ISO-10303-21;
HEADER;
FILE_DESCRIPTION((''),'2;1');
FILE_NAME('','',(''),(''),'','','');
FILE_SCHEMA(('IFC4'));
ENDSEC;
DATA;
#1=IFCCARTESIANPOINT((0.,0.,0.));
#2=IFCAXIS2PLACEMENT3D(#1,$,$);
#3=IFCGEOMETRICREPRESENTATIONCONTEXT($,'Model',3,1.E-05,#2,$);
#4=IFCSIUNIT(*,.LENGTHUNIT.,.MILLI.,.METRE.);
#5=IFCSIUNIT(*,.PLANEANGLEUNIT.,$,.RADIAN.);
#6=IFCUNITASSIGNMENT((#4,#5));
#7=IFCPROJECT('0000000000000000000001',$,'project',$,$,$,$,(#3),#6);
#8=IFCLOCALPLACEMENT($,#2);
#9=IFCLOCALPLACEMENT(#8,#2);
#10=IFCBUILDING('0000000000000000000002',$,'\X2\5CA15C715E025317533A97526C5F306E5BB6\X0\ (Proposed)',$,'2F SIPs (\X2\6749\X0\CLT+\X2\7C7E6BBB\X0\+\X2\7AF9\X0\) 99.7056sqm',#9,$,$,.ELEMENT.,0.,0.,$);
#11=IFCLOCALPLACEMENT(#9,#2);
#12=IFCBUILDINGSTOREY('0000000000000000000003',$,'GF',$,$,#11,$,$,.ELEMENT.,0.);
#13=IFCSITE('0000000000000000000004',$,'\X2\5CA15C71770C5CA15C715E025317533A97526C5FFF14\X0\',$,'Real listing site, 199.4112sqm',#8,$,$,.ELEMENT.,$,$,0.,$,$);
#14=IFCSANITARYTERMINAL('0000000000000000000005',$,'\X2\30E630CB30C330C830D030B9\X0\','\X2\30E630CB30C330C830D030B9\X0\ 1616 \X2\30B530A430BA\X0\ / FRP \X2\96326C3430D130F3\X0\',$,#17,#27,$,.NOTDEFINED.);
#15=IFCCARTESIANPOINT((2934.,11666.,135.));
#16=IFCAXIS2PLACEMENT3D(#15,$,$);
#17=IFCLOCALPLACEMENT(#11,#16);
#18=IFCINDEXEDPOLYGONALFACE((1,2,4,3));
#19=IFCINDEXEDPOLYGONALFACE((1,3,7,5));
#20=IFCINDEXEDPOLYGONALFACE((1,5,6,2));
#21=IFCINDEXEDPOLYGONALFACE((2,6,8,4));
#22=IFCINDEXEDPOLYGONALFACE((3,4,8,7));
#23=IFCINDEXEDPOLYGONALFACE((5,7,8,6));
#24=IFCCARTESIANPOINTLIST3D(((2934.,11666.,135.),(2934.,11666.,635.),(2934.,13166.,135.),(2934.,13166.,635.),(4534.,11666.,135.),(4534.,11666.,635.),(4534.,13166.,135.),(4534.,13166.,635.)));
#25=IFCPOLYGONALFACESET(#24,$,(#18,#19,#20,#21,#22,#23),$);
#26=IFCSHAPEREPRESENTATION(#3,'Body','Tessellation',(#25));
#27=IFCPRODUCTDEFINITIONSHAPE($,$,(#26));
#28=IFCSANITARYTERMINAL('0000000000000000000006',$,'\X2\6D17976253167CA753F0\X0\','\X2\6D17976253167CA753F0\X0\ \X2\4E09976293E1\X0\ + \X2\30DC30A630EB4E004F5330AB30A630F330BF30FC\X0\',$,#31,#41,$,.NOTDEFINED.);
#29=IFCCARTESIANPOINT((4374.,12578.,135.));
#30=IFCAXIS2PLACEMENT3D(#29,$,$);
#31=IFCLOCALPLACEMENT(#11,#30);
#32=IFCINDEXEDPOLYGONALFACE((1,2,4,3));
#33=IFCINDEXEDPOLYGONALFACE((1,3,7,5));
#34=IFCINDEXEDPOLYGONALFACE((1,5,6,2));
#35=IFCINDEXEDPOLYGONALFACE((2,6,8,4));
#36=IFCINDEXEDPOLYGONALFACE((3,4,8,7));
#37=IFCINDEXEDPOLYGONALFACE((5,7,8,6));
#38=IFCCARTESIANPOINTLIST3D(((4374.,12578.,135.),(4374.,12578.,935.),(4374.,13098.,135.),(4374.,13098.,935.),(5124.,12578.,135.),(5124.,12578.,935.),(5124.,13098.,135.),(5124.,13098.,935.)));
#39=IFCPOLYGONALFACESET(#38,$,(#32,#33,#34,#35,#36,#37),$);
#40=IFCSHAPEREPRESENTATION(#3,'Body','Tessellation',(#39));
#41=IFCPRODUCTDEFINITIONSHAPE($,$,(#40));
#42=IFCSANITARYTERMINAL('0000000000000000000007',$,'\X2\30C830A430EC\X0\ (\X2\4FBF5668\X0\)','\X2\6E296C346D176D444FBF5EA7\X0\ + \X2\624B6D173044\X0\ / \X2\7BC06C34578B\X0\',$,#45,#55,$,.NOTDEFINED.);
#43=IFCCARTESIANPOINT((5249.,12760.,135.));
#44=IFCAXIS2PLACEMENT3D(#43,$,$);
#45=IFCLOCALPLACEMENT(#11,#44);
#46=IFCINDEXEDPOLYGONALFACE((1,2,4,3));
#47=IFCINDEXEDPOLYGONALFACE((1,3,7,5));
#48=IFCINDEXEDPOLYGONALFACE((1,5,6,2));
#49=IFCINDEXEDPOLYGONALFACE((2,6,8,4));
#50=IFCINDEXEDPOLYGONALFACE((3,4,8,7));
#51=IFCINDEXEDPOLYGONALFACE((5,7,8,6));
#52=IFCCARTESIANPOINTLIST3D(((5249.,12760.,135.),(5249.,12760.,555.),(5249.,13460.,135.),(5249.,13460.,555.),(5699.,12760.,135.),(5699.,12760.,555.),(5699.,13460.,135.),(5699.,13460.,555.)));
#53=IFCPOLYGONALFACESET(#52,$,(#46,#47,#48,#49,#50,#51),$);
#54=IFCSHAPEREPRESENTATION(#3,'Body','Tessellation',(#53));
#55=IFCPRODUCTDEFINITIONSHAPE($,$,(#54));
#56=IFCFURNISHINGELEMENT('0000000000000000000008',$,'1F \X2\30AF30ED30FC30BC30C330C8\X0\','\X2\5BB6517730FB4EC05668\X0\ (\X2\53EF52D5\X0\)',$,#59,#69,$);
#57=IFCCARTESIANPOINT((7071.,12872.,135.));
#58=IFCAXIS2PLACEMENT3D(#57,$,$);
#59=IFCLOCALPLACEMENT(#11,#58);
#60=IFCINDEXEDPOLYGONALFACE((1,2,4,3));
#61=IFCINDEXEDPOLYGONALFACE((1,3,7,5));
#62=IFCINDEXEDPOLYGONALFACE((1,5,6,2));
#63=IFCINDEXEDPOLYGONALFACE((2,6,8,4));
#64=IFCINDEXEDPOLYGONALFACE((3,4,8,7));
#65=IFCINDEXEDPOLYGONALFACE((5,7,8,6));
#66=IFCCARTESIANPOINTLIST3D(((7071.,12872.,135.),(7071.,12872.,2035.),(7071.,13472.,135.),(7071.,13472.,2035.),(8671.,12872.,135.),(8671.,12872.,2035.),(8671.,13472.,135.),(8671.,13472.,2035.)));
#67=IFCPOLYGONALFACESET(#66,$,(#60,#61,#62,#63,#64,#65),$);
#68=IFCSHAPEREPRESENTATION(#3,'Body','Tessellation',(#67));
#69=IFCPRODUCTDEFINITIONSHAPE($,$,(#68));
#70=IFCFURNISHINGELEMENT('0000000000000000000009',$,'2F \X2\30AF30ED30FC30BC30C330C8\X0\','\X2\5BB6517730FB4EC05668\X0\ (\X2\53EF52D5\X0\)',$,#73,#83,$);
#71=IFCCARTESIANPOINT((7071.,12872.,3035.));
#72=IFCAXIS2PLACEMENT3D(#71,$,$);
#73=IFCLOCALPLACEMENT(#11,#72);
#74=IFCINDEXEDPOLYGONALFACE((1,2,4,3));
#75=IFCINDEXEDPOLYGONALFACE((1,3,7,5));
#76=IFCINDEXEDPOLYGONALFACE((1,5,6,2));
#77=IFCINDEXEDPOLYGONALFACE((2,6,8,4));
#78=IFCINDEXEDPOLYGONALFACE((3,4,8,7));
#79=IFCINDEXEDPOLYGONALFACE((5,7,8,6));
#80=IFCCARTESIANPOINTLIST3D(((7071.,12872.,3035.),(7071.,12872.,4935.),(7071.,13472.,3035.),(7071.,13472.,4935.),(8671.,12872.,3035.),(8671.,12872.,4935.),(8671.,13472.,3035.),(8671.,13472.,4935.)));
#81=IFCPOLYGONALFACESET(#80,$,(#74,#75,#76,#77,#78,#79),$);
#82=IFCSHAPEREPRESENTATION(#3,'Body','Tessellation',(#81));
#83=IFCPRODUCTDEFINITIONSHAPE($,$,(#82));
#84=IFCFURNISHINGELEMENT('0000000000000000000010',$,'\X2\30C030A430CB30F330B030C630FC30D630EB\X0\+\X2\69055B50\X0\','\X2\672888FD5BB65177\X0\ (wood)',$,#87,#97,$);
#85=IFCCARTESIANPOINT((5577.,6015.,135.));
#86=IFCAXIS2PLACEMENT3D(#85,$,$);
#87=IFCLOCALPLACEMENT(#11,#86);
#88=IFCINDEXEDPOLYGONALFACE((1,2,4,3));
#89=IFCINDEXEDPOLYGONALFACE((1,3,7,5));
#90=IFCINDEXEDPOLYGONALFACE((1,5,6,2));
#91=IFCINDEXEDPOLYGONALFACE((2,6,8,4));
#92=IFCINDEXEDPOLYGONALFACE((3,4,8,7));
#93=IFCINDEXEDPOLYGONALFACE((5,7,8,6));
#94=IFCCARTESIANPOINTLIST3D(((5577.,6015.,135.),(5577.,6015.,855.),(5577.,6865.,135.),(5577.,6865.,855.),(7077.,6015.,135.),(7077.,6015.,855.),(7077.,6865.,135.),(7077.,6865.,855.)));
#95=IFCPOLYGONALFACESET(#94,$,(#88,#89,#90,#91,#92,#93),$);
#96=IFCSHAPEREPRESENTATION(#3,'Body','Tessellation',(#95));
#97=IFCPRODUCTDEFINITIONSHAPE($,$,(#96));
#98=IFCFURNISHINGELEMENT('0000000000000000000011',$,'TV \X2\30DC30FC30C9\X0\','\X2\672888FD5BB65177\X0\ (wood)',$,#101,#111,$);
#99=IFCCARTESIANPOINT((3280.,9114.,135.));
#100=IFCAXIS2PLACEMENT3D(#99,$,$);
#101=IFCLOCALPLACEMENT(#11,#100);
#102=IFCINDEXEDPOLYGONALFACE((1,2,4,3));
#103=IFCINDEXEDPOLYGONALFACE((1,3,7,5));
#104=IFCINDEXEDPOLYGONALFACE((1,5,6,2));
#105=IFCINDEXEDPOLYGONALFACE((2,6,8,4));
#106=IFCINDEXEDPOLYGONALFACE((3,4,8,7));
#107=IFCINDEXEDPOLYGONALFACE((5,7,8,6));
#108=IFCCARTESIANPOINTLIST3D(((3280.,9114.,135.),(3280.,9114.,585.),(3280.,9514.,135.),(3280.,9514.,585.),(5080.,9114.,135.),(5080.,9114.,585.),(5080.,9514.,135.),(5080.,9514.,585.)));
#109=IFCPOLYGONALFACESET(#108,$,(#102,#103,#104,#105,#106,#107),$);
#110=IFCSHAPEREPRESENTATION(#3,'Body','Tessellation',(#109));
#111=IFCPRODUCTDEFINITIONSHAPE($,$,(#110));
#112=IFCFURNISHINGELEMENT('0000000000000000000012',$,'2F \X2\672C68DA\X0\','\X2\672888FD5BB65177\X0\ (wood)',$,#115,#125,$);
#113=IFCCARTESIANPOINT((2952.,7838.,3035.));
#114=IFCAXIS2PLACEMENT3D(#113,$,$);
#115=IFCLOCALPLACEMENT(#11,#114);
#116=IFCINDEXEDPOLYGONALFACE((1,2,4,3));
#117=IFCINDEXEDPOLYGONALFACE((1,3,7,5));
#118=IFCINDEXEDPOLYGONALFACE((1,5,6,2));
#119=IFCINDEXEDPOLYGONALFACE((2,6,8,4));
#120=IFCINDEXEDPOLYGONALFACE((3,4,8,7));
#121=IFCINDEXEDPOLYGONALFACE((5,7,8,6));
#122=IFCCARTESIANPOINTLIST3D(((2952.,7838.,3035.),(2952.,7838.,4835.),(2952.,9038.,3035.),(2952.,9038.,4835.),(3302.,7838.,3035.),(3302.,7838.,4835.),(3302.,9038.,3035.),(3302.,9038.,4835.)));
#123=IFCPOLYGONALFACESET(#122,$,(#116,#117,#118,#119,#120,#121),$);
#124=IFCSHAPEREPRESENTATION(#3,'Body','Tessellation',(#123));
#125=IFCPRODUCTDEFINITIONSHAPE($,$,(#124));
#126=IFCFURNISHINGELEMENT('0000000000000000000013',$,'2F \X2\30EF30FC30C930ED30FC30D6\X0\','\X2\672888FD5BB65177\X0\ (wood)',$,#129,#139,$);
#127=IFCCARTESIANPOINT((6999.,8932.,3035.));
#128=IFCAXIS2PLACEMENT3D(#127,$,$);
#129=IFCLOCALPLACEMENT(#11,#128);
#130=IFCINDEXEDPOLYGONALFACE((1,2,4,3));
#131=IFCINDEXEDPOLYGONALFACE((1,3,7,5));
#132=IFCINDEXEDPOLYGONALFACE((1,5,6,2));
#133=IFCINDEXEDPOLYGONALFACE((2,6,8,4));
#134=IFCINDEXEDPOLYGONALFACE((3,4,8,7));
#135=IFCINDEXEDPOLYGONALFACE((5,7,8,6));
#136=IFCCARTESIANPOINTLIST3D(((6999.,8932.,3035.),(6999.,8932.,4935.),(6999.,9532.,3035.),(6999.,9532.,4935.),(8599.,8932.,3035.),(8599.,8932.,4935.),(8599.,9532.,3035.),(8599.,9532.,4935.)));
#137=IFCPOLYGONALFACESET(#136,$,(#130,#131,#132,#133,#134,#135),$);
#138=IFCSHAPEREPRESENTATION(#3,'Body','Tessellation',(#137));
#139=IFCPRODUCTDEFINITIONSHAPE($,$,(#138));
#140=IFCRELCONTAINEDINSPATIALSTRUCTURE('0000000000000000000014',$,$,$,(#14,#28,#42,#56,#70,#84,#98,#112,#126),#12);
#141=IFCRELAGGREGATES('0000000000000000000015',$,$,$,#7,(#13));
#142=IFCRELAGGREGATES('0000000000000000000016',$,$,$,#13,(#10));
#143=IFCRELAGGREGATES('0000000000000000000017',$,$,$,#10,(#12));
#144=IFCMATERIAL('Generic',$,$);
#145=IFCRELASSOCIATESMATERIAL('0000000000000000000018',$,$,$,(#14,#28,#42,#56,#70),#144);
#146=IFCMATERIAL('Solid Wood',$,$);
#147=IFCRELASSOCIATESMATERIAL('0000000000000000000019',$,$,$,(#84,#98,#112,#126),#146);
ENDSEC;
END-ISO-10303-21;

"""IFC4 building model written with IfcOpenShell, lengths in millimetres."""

from ifc_helpers import new_model, si_unit, frame, frame_2d, origin, place, context, project, spatial, rectangle, extrude, material, element, save


model = new_model("IFC4")

# Units and contexts
model_context = context("Model", 3, precision=1e-05, world=origin())
ifc_project = project(units=[si_unit("LENGTHUNIT", "METRE", prefix="MILLI"), si_unit("PLANEANGLEUNIT", "RADIAN")], contexts=[model_context])

# Site, building, storey
site_placement = place(None, origin())
site = spatial("IfcSite", under=ifc_project, at=site_placement, Name="岡山県岡山市北区青江４", ObjectType="Real listing site, 199.4112sqm", CompositionType="ELEMENT", RefElevation=0.0)
building_placement = place(site_placement, origin())
building = spatial("IfcBuilding", under=site, at=building_placement, Name="岡山市北区青江の家 (Proposed)", ObjectType="2F SIPs (杉CLT+籾殻+竹) 99.7056sqm", CompositionType="ELEMENT", ElevationOfRefHeight=0.0, ElevationOfTerrain=0.0)
storey_placement = place(building_placement, origin())
storey = spatial("IfcBuildingStorey", under=building, at=storey_placement, Name="GF", CompositionType="ELEMENT", Elevation=0.0)

# Shared definitions
ifc_material_1 = material(Name="Solid Wood")

# Shared definitions
ifc_material_2 = material(Name="Generic")

# Sanitary terminals
sanitary_terminal_1_placement = place(storey_placement, frame((2934.0, 11666.0, 135.0)))
element("IfcSanitaryTerminal", 1, at=sanitary_terminal_1_placement, inside=storey, material=ifc_material_2, Name="ユニットバス", Description="ユニットバス 1616 サイズ / FRP 防水パン", PredefinedType="NOTDEFINED", context=model_context, shape_type="SweptSolid", body=[
    extrude(rectangle(XDim=1600.0, YDim=1500.0, at=frame_2d((800.0, 750.0))), frame((2934.0, 11666.0, 135.0)), (0.0, 0.0, 1.0), 500.0),
])
sanitary_terminal_2_placement = place(storey_placement, frame((4374.0, 12578.0, 135.0)))
element("IfcSanitaryTerminal", 2, at=sanitary_terminal_2_placement, inside=storey, material=ifc_material_2, Name="洗面化粧台", Description="洗面化粧台 三面鏡 + ボウル一体カウンター", PredefinedType="NOTDEFINED", context=model_context, shape_type="SweptSolid", body=[
    extrude(rectangle(XDim=750.0, YDim=520.0, at=frame_2d((375.0, 260.0))), frame((4374.0, 12578.0, 135.0)), (0.0, 0.0, 1.0), 800.0),
])
sanitary_terminal_3_placement = place(storey_placement, frame((5249.0, 12760.0, 135.0)))
element("IfcSanitaryTerminal", 3, at=sanitary_terminal_3_placement, inside=storey, material=ifc_material_2, Name="トイレ (便器)", Description="温水洗浄便座 + 手洗い / 節水型", PredefinedType="NOTDEFINED", context=model_context, shape_type="SweptSolid", body=[
    extrude(rectangle(XDim=450.0, YDim=700.0, at=frame_2d((225.0, 350.0))), frame((5249.0, 12760.0, 135.0)), (0.0, 0.0, 1.0), 420.0),
])

# Furnishing elements
furnishing_1_placement = place(storey_placement, frame((7071.0, 12872.0, 135.0)))
element("IfcFurnishingElement", 4, at=furnishing_1_placement, inside=storey, material=ifc_material_2, Name="1F クローゼット", Description="家具・什器 (可動)", context=model_context, shape_type="SweptSolid", body=[
    extrude(rectangle(XDim=1600.0, YDim=600.0, at=frame_2d((800.0, 300.0))), frame((7071.0, 12872.0, 135.0)), (0.0, 0.0, 1.0), 1900.0),
])
furnishing_2_placement = place(storey_placement, frame((7071.0, 12872.0, 3035.0)))
element("IfcFurnishingElement", 5, at=furnishing_2_placement, inside=storey, material=ifc_material_2, Name="2F クローゼット", Description="家具・什器 (可動)", context=model_context, shape_type="SweptSolid", body=[
    extrude(rectangle(XDim=1600.0, YDim=600.0, at=frame_2d((800.0, 300.0))), frame((7071.0, 12872.0, 3035.0)), (0.0, 0.0, 1.0), 1900.0),
])
furnishing_3_placement = place(storey_placement, frame((5577.0, 6015.0, 135.0)))
element("IfcFurnishingElement", 6, at=furnishing_3_placement, inside=storey, material=ifc_material_1, Name="ダイニングテーブル+椅子", Description="木製家具 (wood)", context=model_context, shape_type="SweptSolid", body=[
    extrude(rectangle(XDim=1500.0, YDim=850.0, at=frame_2d((750.0, 425.0))), frame((5577.0, 6015.0, 135.0)), (0.0, 0.0, 1.0), 720.0),
])
furnishing_4_placement = place(storey_placement, frame((3280.0, 9114.0, 135.0)))
element("IfcFurnishingElement", 7, at=furnishing_4_placement, inside=storey, material=ifc_material_1, Name="TV ボード", Description="木製家具 (wood)", context=model_context, shape_type="SweptSolid", body=[
    extrude(rectangle(XDim=1800.0, YDim=400.0, at=frame_2d((900.0, 200.0))), frame((3280.0, 9114.0, 135.0)), (0.0, 0.0, 1.0), 450.0),
])
furnishing_5_placement = place(storey_placement, frame((2952.0, 7838.0, 3035.0)))
element("IfcFurnishingElement", 8, at=furnishing_5_placement, inside=storey, material=ifc_material_1, Name="2F 本棚", Description="木製家具 (wood)", context=model_context, shape_type="SweptSolid", body=[
    extrude(rectangle(XDim=350.0, YDim=1200.0, at=frame_2d((175.0, 600.0))), frame((2952.0, 7838.0, 3035.0)), (0.0, 0.0, 1.0), 1800.0),
])
furnishing_6_placement = place(storey_placement, frame((6999.0, 8932.0, 3035.0)))
element("IfcFurnishingElement", 9, at=furnishing_6_placement, inside=storey, material=ifc_material_1, Name="2F ワードローブ", Description="木製家具 (wood)", context=model_context, shape_type="SweptSolid", body=[
    extrude(rectangle(XDim=1600.0, YDim=600.0, at=frame_2d((800.0, 300.0))), frame((6999.0, 8932.0, 3035.0)), (0.0, 0.0, 1.0), 1900.0),
])

save(model, "model.ifc")
